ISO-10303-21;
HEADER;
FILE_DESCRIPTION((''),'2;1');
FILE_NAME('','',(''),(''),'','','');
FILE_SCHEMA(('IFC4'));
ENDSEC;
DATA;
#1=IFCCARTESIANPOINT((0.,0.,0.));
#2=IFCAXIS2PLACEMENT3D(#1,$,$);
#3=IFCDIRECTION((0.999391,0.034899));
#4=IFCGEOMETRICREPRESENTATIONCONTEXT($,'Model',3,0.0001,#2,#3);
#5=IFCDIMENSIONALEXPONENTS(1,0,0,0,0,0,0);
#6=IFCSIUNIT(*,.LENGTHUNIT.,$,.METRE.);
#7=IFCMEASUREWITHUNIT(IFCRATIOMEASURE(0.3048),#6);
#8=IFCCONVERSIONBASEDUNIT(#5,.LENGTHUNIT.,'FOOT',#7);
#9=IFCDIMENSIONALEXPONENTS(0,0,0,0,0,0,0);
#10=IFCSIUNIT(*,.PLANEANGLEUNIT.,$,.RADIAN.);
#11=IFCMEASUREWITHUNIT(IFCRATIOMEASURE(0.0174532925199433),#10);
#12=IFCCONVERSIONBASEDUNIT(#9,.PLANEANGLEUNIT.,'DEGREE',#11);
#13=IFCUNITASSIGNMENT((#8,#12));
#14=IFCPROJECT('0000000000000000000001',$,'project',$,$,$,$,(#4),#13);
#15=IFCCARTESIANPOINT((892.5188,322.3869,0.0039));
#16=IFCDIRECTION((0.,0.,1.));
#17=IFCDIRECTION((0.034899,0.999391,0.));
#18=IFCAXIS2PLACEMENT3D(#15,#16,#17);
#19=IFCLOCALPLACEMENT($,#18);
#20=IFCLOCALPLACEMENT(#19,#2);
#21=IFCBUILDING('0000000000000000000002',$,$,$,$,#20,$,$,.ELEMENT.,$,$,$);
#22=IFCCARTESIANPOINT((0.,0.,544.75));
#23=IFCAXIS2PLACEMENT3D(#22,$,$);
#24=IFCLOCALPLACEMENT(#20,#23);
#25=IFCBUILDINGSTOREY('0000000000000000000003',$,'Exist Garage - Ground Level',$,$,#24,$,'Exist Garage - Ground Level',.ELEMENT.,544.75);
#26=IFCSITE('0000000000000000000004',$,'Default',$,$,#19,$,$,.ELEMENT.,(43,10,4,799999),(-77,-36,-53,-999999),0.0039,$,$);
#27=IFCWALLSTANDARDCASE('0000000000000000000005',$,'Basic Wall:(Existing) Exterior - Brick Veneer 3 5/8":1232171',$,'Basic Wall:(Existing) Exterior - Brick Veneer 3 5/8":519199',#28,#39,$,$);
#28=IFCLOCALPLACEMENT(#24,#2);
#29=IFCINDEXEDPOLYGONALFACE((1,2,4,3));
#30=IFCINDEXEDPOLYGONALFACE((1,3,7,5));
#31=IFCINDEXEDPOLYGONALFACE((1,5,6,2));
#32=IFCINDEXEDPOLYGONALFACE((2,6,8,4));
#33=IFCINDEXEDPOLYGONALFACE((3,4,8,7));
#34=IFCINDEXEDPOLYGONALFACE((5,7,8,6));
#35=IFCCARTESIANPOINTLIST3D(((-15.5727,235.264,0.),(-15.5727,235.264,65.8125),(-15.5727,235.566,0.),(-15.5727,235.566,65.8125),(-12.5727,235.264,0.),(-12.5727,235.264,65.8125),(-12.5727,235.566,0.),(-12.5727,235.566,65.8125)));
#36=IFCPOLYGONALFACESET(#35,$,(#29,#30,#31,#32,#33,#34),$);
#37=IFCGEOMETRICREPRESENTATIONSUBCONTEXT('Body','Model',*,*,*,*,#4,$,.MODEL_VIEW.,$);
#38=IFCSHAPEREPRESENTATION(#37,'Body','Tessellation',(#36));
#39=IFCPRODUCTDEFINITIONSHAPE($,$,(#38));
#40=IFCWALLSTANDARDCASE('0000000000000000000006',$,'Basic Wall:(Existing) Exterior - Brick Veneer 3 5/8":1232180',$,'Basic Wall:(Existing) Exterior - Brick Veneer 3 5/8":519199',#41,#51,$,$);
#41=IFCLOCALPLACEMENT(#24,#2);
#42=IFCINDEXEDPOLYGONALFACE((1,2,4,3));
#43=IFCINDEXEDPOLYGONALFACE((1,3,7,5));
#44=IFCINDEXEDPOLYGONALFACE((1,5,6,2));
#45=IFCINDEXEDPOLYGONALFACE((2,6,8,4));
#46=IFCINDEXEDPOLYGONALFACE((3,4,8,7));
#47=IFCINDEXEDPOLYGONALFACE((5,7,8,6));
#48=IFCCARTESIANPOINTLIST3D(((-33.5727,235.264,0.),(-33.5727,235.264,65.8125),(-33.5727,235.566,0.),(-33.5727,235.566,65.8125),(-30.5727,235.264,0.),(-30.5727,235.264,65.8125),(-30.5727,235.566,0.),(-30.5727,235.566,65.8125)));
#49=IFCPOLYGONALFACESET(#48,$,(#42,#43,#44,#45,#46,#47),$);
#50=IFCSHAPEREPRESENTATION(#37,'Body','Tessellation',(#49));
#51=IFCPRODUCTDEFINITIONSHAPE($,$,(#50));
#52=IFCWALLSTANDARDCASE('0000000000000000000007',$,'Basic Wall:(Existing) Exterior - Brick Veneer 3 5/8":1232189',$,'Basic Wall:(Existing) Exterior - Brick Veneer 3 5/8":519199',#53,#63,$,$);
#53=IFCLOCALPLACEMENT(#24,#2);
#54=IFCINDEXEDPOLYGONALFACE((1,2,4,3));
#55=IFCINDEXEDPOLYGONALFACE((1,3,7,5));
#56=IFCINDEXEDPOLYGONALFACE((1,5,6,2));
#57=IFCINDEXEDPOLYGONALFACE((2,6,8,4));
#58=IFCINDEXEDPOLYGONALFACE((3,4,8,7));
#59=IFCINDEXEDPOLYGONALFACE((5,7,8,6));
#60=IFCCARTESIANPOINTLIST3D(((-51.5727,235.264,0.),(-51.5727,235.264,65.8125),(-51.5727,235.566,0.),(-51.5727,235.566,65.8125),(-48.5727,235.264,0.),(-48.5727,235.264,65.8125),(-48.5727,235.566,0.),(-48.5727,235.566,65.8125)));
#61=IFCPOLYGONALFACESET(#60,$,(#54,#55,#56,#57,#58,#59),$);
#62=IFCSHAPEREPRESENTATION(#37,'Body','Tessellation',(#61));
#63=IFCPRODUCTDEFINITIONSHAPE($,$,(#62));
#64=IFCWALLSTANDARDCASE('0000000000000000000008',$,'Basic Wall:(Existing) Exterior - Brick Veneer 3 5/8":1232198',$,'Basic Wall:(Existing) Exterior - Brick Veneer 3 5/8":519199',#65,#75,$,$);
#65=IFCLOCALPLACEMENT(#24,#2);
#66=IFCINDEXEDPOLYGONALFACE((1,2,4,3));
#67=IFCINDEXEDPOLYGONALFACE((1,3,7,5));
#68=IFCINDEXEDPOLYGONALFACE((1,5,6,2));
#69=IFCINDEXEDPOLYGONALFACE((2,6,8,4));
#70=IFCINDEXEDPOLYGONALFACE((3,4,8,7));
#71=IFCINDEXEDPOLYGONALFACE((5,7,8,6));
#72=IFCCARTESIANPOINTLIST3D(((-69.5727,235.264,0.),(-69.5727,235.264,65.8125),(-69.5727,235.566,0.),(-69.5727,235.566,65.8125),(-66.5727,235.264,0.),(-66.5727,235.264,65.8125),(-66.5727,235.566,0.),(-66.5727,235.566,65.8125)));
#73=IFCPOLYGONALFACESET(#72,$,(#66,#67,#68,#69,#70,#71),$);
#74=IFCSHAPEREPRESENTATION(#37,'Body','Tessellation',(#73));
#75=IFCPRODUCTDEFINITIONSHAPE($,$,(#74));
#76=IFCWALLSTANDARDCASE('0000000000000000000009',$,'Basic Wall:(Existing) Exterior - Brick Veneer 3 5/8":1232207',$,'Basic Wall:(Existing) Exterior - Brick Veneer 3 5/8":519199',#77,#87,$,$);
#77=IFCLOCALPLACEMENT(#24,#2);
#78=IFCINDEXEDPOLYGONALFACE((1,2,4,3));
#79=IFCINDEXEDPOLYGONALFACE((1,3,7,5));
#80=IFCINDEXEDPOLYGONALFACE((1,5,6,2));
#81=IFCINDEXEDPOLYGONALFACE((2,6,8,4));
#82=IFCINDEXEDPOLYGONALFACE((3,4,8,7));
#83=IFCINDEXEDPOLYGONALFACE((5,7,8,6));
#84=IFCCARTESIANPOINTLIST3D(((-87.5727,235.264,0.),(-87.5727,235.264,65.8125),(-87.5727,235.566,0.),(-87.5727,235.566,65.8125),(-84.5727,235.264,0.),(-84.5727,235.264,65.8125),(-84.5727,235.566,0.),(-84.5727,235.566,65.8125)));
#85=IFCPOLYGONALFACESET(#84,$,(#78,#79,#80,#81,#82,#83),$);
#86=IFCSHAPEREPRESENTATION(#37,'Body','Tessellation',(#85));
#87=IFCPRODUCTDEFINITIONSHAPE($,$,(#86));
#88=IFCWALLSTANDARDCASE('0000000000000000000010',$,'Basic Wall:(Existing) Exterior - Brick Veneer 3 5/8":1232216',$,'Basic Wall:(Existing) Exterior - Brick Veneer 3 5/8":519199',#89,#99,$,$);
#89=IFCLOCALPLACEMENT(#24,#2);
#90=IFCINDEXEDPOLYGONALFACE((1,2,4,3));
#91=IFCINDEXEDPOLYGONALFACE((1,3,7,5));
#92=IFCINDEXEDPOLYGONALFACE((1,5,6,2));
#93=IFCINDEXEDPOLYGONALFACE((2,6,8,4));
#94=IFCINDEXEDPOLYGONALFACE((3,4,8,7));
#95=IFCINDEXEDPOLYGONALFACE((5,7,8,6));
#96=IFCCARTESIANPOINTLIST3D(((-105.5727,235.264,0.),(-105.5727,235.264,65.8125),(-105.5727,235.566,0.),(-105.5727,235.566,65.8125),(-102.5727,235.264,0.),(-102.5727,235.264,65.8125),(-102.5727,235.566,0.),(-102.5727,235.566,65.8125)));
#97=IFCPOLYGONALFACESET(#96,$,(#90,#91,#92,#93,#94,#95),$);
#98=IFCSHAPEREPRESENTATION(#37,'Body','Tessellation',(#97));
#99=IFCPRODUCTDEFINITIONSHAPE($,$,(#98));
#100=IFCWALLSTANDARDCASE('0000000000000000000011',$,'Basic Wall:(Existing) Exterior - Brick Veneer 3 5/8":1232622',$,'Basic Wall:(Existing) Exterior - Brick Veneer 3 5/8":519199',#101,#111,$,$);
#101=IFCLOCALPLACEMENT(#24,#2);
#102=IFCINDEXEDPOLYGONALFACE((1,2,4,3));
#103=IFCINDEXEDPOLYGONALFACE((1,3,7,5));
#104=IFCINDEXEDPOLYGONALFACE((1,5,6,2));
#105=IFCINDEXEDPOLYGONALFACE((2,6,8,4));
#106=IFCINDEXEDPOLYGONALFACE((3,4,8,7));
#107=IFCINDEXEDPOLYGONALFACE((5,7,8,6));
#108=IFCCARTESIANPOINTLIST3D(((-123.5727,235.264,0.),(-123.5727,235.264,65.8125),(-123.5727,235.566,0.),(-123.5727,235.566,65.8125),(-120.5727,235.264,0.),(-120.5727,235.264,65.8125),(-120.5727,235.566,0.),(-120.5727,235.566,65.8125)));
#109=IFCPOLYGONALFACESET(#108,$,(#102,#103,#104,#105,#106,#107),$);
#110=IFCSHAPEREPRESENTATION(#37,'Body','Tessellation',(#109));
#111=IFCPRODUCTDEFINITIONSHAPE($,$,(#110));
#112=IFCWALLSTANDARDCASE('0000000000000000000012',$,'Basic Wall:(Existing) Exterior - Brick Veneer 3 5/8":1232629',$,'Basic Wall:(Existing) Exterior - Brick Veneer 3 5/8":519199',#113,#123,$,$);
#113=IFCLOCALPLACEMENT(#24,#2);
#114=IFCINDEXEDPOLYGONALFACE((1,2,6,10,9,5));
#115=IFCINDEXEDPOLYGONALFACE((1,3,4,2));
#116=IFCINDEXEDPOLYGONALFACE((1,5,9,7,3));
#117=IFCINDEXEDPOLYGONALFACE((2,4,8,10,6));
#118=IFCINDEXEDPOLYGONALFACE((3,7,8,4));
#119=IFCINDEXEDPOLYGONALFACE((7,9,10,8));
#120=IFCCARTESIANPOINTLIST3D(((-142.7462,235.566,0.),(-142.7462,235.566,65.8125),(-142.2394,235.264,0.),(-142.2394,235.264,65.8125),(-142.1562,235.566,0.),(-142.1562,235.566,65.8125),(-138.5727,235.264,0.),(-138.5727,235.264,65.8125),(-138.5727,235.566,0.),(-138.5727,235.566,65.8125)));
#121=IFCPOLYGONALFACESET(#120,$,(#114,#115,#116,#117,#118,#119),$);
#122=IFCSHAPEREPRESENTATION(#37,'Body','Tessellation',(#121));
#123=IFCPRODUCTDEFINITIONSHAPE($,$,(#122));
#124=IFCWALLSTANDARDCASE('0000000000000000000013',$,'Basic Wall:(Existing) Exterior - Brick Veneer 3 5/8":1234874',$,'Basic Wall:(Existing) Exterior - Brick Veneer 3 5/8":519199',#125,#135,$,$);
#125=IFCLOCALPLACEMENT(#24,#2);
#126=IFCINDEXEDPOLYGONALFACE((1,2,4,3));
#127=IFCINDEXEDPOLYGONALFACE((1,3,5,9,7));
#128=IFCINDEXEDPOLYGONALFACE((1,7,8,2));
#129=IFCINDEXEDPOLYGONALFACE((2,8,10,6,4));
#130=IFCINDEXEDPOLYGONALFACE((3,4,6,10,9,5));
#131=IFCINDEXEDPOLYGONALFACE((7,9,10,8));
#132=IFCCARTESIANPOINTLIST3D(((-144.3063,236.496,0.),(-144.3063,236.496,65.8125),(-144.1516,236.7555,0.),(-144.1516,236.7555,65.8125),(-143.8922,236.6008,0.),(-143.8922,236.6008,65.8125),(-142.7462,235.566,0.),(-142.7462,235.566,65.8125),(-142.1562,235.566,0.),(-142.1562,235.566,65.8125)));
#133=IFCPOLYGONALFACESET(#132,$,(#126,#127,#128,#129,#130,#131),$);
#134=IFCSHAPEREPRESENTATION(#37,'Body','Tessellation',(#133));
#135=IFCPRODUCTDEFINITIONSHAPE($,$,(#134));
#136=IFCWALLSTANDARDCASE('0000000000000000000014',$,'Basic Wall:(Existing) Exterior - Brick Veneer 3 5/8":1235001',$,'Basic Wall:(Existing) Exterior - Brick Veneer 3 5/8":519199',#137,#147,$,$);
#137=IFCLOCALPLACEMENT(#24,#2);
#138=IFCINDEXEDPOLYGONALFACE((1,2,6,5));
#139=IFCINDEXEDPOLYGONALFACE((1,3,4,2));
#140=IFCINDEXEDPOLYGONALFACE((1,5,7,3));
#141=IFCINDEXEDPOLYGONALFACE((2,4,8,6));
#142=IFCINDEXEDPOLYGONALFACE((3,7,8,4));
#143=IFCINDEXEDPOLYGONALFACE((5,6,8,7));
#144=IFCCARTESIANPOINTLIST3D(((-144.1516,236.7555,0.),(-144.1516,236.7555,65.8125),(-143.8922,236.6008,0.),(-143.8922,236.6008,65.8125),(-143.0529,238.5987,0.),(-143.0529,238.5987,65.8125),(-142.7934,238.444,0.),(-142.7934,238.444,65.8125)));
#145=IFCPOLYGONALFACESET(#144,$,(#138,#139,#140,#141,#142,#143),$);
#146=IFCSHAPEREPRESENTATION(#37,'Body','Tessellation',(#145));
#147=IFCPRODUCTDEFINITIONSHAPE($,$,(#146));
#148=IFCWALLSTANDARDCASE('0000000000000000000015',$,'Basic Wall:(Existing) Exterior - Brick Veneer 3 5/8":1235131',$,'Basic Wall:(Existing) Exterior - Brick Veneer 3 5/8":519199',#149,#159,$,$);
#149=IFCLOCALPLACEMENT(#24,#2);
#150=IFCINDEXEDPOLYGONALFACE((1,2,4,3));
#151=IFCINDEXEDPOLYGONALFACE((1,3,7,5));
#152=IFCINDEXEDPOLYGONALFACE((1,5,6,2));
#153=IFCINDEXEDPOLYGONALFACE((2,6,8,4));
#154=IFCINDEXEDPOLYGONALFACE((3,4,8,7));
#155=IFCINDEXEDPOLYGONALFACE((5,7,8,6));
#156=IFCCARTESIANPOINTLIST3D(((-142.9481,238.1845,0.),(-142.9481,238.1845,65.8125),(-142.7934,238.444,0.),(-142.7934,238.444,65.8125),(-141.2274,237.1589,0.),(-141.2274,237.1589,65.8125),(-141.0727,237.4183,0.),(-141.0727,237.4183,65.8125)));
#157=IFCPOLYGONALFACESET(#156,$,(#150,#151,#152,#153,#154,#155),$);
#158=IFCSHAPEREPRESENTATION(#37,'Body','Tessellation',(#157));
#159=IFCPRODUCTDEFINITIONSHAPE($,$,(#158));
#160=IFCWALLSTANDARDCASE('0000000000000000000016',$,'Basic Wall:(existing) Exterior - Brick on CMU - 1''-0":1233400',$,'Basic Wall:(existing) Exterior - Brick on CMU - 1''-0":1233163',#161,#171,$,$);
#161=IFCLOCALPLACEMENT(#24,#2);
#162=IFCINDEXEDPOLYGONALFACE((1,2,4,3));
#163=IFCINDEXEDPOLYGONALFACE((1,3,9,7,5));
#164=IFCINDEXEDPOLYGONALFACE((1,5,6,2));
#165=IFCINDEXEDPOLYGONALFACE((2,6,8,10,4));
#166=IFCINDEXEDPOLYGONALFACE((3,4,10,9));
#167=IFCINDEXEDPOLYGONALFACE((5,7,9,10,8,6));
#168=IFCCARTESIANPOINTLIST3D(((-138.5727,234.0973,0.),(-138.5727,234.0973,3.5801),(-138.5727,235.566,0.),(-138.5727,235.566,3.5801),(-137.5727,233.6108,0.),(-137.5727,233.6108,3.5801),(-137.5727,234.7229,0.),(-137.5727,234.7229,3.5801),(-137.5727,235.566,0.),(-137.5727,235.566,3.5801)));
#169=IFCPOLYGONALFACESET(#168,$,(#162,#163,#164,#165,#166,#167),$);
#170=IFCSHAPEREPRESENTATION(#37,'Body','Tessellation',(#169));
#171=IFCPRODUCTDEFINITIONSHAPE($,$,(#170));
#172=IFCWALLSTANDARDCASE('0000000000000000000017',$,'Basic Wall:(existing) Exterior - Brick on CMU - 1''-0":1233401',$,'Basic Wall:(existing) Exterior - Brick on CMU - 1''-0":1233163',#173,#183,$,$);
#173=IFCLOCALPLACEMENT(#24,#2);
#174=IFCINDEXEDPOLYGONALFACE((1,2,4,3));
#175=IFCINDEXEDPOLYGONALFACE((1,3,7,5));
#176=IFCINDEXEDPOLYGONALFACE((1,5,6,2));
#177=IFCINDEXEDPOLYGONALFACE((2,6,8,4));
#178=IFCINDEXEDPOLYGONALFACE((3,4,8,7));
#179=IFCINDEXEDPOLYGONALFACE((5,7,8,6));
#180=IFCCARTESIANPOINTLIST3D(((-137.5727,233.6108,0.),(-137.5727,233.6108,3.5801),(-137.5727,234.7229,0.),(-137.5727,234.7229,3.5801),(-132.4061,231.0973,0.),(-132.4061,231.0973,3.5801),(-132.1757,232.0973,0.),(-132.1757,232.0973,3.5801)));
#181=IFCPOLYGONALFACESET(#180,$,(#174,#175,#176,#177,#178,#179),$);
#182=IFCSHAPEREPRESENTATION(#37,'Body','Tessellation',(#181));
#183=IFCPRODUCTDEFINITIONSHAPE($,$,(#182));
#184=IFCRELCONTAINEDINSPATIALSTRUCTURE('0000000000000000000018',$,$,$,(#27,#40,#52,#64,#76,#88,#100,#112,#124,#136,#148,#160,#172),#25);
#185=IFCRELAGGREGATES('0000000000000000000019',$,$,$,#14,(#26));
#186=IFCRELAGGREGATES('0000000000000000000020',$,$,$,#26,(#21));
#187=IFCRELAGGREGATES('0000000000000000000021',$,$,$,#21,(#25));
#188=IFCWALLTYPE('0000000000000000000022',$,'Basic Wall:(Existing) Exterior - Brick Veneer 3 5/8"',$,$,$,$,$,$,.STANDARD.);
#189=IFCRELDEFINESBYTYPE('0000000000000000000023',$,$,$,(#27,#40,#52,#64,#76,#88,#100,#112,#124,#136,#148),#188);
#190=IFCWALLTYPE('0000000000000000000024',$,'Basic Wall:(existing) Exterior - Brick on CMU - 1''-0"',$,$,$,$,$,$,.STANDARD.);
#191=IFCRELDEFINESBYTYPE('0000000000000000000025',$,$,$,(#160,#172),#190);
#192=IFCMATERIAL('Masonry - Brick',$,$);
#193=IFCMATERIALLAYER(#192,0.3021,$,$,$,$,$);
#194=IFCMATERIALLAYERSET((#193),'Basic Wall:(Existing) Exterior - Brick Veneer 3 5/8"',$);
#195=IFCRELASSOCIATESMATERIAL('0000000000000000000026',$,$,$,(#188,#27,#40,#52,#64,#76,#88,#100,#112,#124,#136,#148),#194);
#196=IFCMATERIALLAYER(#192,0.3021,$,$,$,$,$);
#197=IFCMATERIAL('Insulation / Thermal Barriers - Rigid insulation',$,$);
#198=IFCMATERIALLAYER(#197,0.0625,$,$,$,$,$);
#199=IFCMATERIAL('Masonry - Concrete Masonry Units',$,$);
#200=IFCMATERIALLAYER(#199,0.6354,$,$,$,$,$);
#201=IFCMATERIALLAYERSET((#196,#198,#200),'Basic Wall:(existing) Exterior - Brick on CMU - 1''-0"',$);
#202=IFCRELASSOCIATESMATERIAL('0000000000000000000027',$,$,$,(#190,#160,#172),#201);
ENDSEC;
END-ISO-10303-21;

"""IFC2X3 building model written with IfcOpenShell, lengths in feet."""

from ifc_helpers import new_model, entity, si_unit, converted_unit, direction, frame, frame_2d, origin, place, context, subcontext, project, spatial, polyline, rectangle, outline, extrude, material, layer, layer_set, layer_usage, type_object, element, save


model = new_model("IFC2X3")

# Units and contexts
model_context = context("Model", 3, precision=0.0001, world=origin(), true_north=direction((0.999391, 0.034899)))
body_context = subcontext(model_context, "Body", "Model", "MODEL_VIEW")
ifc_project = project(units=[converted_unit("LENGTHUNIT", "FOOT", entity("IfcRatioMeasure", 0.3048), si_unit("LENGTHUNIT", "METRE"), dimensions=[1, 0, 0, 0, 0, 0, 0]), converted_unit("PLANEANGLEUNIT", "DEGREE", entity("IfcRatioMeasure", 0.0174532925199433), si_unit("PLANEANGLEUNIT", "RADIAN"), dimensions=[0, 0, 0, 0, 0, 0, 0])], contexts=[model_context])

# Site, building, storey
site_placement = place(None, frame((892.5188, 322.3869, 0.0039), z_axis=(0.0, 0.0, 1.0), x_axis=(0.034899, 0.999391, 0.0)))
site = spatial("IfcSite", under=ifc_project, at=site_placement, Name="Default", CompositionType="ELEMENT", RefLatitude=(43, 10, 4, 799999), RefLongitude=(-77, -36, -53, -999999), RefElevation=0.0039)
building_placement = place(site_placement, origin())
building = spatial("IfcBuilding", under=site, at=building_placement, CompositionType="ELEMENT")
storey_placement = place(building_placement, frame((0.0, 0.0, 544.75)))
storey = spatial("IfcBuildingStorey", under=building, at=storey_placement, Name="Exist Garage - Ground Level", LongName="Exist Garage - Ground Level", CompositionType="ELEMENT", Elevation=544.75)

# Walls
ifc_material_1 = material(Name="Masonry - Brick")
ifc_layer_1 = layer(ifc_material_1, 0.3021)
ifc_layer_set_1 = layer_set([ifc_layer_1], Name="Basic Wall:(Existing) Exterior - Brick Veneer 3 5/8\"")
ifc_layer_usage_1 = layer_usage(ifc_layer_set_1, "AXIS2", "POSITIVE", -0.151)
wall_type_1 = type_object("IfcWallType", Name="Basic Wall:(Existing) Exterior - Brick Veneer 3 5/8\"", PredefinedType="STANDARD", material=ifc_layer_set_1)
wall_1_placement = place(storey_placement, frame((-15.5727, 235.415, 0.0)))
element("IfcWallStandardCase", 1, at=wall_1_placement, inside=storey, type_object=wall_type_1, material=ifc_layer_usage_1, Name="Basic Wall:(Existing) Exterior - Brick Veneer 3 5/8\":1232171", ObjectType="Basic Wall:(Existing) Exterior - Brick Veneer 3 5/8\":519199", context=body_context, shape_type="SweptSolid", body=[
    extrude(rectangle(XDim=3.0, YDim=0.3021, at=frame_2d((1.5, 0.0), x_axis=(-1.0, 0.0))), origin(), (0.0, 0.0, 1.0), 65.8125),
])
ifc_layer_usage_2 = layer_usage(ifc_layer_set_1, "AXIS2", "POSITIVE", -0.151)
wall_2_placement = place(storey_placement, frame((-33.5727, 235.415, 0.0)))
element("IfcWallStandardCase", 2, at=wall_2_placement, inside=storey, type_object=wall_type_1, material=ifc_layer_usage_2, Name="Basic Wall:(Existing) Exterior - Brick Veneer 3 5/8\":1232180", ObjectType="Basic Wall:(Existing) Exterior - Brick Veneer 3 5/8\":519199", context=body_context, shape_type="SweptSolid", body=[
    extrude(rectangle(XDim=3.0, YDim=0.3021, at=frame_2d((1.5, 0.0), x_axis=(-1.0, 0.0))), origin(), (0.0, 0.0, 1.0), 65.8125),
])
ifc_layer_usage_3 = layer_usage(ifc_layer_set_1, "AXIS2", "POSITIVE", -0.151)
wall_3_placement = place(storey_placement, frame((-51.5727, 235.415, 0.0)))
element("IfcWallStandardCase", 3, at=wall_3_placement, inside=storey, type_object=wall_type_1, material=ifc_layer_usage_3, Name="Basic Wall:(Existing) Exterior - Brick Veneer 3 5/8\":1232189", ObjectType="Basic Wall:(Existing) Exterior - Brick Veneer 3 5/8\":519199", context=body_context, shape_type="SweptSolid", body=[
    extrude(rectangle(XDim=3.0, YDim=0.3021, at=frame_2d((1.5, 0.0), x_axis=(-1.0, 0.0))), origin(), (0.0, 0.0, 1.0), 65.8125),
])
ifc_layer_usage_4 = layer_usage(ifc_layer_set_1, "AXIS2", "POSITIVE", -0.151)
wall_4_placement = place(storey_placement, frame((-69.5727, 235.415, 0.0)))
element("IfcWallStandardCase", 4, at=wall_4_placement, inside=storey, type_object=wall_type_1, material=ifc_layer_usage_4, Name="Basic Wall:(Existing) Exterior - Brick Veneer 3 5/8\":1232198", ObjectType="Basic Wall:(Existing) Exterior - Brick Veneer 3 5/8\":519199", context=body_context, shape_type="SweptSolid", body=[
    extrude(rectangle(XDim=3.0, YDim=0.3021, at=frame_2d((1.5, 0.0), x_axis=(-1.0, 0.0))), origin(), (0.0, 0.0, 1.0), 65.8125),
])
ifc_layer_usage_5 = layer_usage(ifc_layer_set_1, "AXIS2", "POSITIVE", -0.151)
wall_5_placement = place(storey_placement, frame((-87.5727, 235.415, 0.0)))
element("IfcWallStandardCase", 5, at=wall_5_placement, inside=storey, type_object=wall_type_1, material=ifc_layer_usage_5, Name="Basic Wall:(Existing) Exterior - Brick Veneer 3 5/8\":1232207", ObjectType="Basic Wall:(Existing) Exterior - Brick Veneer 3 5/8\":519199", context=body_context, shape_type="SweptSolid", body=[
    extrude(rectangle(XDim=3.0, YDim=0.3021, at=frame_2d((1.5, 0.0), x_axis=(-1.0, 0.0))), origin(), (0.0, 0.0, 1.0), 65.8125),
])
ifc_layer_usage_6 = layer_usage(ifc_layer_set_1, "AXIS2", "POSITIVE", -0.151)
wall_6_placement = place(storey_placement, frame((-105.5727, 235.415, 0.0)))
element("IfcWallStandardCase", 6, at=wall_6_placement, inside=storey, type_object=wall_type_1, material=ifc_layer_usage_6, Name="Basic Wall:(Existing) Exterior - Brick Veneer 3 5/8\":1232216", ObjectType="Basic Wall:(Existing) Exterior - Brick Veneer 3 5/8\":519199", context=body_context, shape_type="SweptSolid", body=[
    extrude(rectangle(XDim=3.0, YDim=0.3021, at=frame_2d((1.5, 0.0), x_axis=(-1.0, 0.0))), origin(), (0.0, 0.0, 1.0), 65.8125),
])
ifc_layer_usage_7 = layer_usage(ifc_layer_set_1, "AXIS2", "POSITIVE", -0.151)
wall_7_placement = place(storey_placement, frame((-123.5727, 235.415, 0.0)))
element("IfcWallStandardCase", 7, at=wall_7_placement, inside=storey, type_object=wall_type_1, material=ifc_layer_usage_7, Name="Basic Wall:(Existing) Exterior - Brick Veneer 3 5/8\":1232622", ObjectType="Basic Wall:(Existing) Exterior - Brick Veneer 3 5/8\":519199", context=body_context, shape_type="SweptSolid", body=[
    extrude(rectangle(XDim=3.0, YDim=0.3021, at=frame_2d((1.5, 0.0), x_axis=(-1.0, 0.0))), origin(), (0.0, 0.0, 1.0), 65.8125),
])
ifc_layer_usage_8 = layer_usage(ifc_layer_set_1, "AXIS2", "POSITIVE", -0.151)
wall_8_placement = place(storey_placement, frame((-142.7462, 235.415, 0.0)))
element("IfcWallStandardCase", 8, at=wall_8_placement, inside=storey, type_object=wall_type_1, material=ifc_layer_usage_8, Name="Basic Wall:(Existing) Exterior - Brick Veneer 3 5/8\":1232629", ObjectType="Basic Wall:(Existing) Exterior - Brick Veneer 3 5/8\":519199", context=body_context, shape_type="SweptSolid", body=[
    extrude(outline(polyline([(4.1734, -0.151), (4.1734, 0.151), (0.59, 0.151), (0.0, 0.151), (0.5068, -0.151), (4.1734, -0.151)])), origin(), (0.0, 0.0, 1.0), 65.8125),
])
ifc_layer_usage_9 = layer_usage(ifc_layer_set_1, "AXIS2", "POSITIVE", -0.151)
wall_9_placement = place(storey_placement, frame((-144.229, 236.6257, 0.0), z_axis=(0.0, 0.0, 1.0), x_axis=(0.858972, -0.512022, 0.0)))
element("IfcWallStandardCase", 9, at=wall_9_placement, inside=storey, type_object=wall_type_1, material=ifc_layer_usage_9, Name="Basic Wall:(Existing) Exterior - Brick Veneer 3 5/8\":1234874", ObjectType="Basic Wall:(Existing) Exterior - Brick Veneer 3 5/8\":519199", context=body_context, shape_type="SweptSolid", body=[
    extrude(outline(polyline([(1.8163, -0.151), (2.323, 0.151), (0.3021, 0.151), (0.0, 0.151), (0.0, -0.151), (1.8163, -0.151)])), origin(), (0.0, 0.0, 1.0), 65.8125),
])
ifc_layer_usage_10 = layer_usage(ifc_layer_set_1, "AXIS2", "NEGATIVE", 0.151)
wall_10_placement = place(storey_placement, frame((-144.0219, 236.6782, 0.0), z_axis=(0.0, 0.0, 1.0), x_axis=(0.512022, 0.858972, 0.0)))
element("IfcWallStandardCase", 10, at=wall_10_placement, inside=storey, type_object=wall_type_1, material=ifc_layer_usage_10, Name="Basic Wall:(Existing) Exterior - Brick Veneer 3 5/8\":1235001", ObjectType="Basic Wall:(Existing) Exterior - Brick Veneer 3 5/8\":519199", context=body_context, shape_type="SweptSolid", body=[
    extrude(rectangle(XDim=2.1458, YDim=0.3021, at=frame_2d((1.0729, 0.0), x_axis=(-1.0, 0.0))), origin(), (0.0, 0.0, 1.0), 65.8125),
])
ifc_layer_usage_11 = layer_usage(ifc_layer_set_1, "AXIS2", "NEGATIVE", 0.151)
wall_11_placement = place(storey_placement, frame((-142.8708, 238.3143, 0.0), z_axis=(0.0, 0.0, 1.0), x_axis=(0.858972, -0.512022, 0.0)))
element("IfcWallStandardCase", 11, at=wall_11_placement, inside=storey, type_object=wall_type_1, material=ifc_layer_usage_11, Name="Basic Wall:(Existing) Exterior - Brick Veneer 3 5/8\":1235131", ObjectType="Basic Wall:(Existing) Exterior - Brick Veneer 3 5/8\":519199", context=body_context, shape_type="SweptSolid", body=[
    extrude(rectangle(XDim=2.0032, YDim=0.3021, at=frame_2d((1.0016, 0.0), x_axis=(-1.0, 0.0))), origin(), (0.0, 0.0, 1.0), 65.8125),
])
ifc_layer_2 = layer(ifc_material_1, 0.3021)
ifc_material_2 = material(Name="Insulation / Thermal Barriers - Rigid insulation")
ifc_layer_3 = layer(ifc_material_2, 0.0625)
ifc_material_3 = material(Name="Masonry - Concrete Masonry Units")
ifc_layer_4 = layer(ifc_material_3, 0.6354)
ifc_layer_set_2 = layer_set([ifc_layer_2, ifc_layer_3, ifc_layer_4], Name="Basic Wall:(existing) Exterior - Brick on CMU - 1'-0\"")
ifc_layer_usage_12 = layer_usage(ifc_layer_set_2, "AXIS2", "POSITIVE", -0.5)
wall_type_2 = type_object("IfcWallType", Name="Basic Wall:(existing) Exterior - Brick on CMU - 1'-0\"", PredefinedType="STANDARD", material=ifc_layer_set_2)
wall_12_placement = place(storey_placement, frame((-138.0727, 235.566, 0.0), z_axis=(0.0, 0.0, 1.0), x_axis=(0.0, -1.0, 0.0)))
element("IfcWallStandardCase", 12, at=wall_12_placement, inside=storey, type_object=wall_type_2, material=ifc_layer_usage_12, Name="Basic Wall:(existing) Exterior - Brick on CMU - 1'-0\":1233400", ObjectType="Basic Wall:(existing) Exterior - Brick on CMU - 1'-0\":1233163", context=body_context, shape_type="SweptSolid", body=[
    extrude(outline(polyline([(1.4688, -0.5), (1.9552, 0.5), (0.8432, 0.5), (0.0, 0.5), (0.0, -0.5), (1.4688, -0.5)])), origin(), (0.0, 0.0, 1.0), 3.5801),
])
ifc_layer_usage_13 = layer_usage(ifc_layer_set_2, "AXIS2", "POSITIVE", -0.5)
wall_13_placement = place(storey_placement, frame((-137.7915, 234.2732, 0.0), z_axis=(0.0, 0.0, 1.0), x_axis=(0.899235, -0.437466, 0.0)))
element("IfcWallStandardCase", 13, at=wall_13_placement, inside=storey, type_object=wall_type_2, material=ifc_layer_usage_13, Name="Basic Wall:(existing) Exterior - Brick on CMU - 1'-0\":1233401", ObjectType="Basic Wall:(existing) Exterior - Brick on CMU - 1'-0\":1233163", context=body_context, shape_type="SweptSolid", body=[
    extrude(outline(polyline([(6.2321, -0.5), (6.0018, 0.5), (0.0, 0.5), (0.4865, -0.5), (6.2321, -0.5)])), origin(), (0.0, 0.0, 1.0), 3.5801),
])

save(model, "model.ifc")
